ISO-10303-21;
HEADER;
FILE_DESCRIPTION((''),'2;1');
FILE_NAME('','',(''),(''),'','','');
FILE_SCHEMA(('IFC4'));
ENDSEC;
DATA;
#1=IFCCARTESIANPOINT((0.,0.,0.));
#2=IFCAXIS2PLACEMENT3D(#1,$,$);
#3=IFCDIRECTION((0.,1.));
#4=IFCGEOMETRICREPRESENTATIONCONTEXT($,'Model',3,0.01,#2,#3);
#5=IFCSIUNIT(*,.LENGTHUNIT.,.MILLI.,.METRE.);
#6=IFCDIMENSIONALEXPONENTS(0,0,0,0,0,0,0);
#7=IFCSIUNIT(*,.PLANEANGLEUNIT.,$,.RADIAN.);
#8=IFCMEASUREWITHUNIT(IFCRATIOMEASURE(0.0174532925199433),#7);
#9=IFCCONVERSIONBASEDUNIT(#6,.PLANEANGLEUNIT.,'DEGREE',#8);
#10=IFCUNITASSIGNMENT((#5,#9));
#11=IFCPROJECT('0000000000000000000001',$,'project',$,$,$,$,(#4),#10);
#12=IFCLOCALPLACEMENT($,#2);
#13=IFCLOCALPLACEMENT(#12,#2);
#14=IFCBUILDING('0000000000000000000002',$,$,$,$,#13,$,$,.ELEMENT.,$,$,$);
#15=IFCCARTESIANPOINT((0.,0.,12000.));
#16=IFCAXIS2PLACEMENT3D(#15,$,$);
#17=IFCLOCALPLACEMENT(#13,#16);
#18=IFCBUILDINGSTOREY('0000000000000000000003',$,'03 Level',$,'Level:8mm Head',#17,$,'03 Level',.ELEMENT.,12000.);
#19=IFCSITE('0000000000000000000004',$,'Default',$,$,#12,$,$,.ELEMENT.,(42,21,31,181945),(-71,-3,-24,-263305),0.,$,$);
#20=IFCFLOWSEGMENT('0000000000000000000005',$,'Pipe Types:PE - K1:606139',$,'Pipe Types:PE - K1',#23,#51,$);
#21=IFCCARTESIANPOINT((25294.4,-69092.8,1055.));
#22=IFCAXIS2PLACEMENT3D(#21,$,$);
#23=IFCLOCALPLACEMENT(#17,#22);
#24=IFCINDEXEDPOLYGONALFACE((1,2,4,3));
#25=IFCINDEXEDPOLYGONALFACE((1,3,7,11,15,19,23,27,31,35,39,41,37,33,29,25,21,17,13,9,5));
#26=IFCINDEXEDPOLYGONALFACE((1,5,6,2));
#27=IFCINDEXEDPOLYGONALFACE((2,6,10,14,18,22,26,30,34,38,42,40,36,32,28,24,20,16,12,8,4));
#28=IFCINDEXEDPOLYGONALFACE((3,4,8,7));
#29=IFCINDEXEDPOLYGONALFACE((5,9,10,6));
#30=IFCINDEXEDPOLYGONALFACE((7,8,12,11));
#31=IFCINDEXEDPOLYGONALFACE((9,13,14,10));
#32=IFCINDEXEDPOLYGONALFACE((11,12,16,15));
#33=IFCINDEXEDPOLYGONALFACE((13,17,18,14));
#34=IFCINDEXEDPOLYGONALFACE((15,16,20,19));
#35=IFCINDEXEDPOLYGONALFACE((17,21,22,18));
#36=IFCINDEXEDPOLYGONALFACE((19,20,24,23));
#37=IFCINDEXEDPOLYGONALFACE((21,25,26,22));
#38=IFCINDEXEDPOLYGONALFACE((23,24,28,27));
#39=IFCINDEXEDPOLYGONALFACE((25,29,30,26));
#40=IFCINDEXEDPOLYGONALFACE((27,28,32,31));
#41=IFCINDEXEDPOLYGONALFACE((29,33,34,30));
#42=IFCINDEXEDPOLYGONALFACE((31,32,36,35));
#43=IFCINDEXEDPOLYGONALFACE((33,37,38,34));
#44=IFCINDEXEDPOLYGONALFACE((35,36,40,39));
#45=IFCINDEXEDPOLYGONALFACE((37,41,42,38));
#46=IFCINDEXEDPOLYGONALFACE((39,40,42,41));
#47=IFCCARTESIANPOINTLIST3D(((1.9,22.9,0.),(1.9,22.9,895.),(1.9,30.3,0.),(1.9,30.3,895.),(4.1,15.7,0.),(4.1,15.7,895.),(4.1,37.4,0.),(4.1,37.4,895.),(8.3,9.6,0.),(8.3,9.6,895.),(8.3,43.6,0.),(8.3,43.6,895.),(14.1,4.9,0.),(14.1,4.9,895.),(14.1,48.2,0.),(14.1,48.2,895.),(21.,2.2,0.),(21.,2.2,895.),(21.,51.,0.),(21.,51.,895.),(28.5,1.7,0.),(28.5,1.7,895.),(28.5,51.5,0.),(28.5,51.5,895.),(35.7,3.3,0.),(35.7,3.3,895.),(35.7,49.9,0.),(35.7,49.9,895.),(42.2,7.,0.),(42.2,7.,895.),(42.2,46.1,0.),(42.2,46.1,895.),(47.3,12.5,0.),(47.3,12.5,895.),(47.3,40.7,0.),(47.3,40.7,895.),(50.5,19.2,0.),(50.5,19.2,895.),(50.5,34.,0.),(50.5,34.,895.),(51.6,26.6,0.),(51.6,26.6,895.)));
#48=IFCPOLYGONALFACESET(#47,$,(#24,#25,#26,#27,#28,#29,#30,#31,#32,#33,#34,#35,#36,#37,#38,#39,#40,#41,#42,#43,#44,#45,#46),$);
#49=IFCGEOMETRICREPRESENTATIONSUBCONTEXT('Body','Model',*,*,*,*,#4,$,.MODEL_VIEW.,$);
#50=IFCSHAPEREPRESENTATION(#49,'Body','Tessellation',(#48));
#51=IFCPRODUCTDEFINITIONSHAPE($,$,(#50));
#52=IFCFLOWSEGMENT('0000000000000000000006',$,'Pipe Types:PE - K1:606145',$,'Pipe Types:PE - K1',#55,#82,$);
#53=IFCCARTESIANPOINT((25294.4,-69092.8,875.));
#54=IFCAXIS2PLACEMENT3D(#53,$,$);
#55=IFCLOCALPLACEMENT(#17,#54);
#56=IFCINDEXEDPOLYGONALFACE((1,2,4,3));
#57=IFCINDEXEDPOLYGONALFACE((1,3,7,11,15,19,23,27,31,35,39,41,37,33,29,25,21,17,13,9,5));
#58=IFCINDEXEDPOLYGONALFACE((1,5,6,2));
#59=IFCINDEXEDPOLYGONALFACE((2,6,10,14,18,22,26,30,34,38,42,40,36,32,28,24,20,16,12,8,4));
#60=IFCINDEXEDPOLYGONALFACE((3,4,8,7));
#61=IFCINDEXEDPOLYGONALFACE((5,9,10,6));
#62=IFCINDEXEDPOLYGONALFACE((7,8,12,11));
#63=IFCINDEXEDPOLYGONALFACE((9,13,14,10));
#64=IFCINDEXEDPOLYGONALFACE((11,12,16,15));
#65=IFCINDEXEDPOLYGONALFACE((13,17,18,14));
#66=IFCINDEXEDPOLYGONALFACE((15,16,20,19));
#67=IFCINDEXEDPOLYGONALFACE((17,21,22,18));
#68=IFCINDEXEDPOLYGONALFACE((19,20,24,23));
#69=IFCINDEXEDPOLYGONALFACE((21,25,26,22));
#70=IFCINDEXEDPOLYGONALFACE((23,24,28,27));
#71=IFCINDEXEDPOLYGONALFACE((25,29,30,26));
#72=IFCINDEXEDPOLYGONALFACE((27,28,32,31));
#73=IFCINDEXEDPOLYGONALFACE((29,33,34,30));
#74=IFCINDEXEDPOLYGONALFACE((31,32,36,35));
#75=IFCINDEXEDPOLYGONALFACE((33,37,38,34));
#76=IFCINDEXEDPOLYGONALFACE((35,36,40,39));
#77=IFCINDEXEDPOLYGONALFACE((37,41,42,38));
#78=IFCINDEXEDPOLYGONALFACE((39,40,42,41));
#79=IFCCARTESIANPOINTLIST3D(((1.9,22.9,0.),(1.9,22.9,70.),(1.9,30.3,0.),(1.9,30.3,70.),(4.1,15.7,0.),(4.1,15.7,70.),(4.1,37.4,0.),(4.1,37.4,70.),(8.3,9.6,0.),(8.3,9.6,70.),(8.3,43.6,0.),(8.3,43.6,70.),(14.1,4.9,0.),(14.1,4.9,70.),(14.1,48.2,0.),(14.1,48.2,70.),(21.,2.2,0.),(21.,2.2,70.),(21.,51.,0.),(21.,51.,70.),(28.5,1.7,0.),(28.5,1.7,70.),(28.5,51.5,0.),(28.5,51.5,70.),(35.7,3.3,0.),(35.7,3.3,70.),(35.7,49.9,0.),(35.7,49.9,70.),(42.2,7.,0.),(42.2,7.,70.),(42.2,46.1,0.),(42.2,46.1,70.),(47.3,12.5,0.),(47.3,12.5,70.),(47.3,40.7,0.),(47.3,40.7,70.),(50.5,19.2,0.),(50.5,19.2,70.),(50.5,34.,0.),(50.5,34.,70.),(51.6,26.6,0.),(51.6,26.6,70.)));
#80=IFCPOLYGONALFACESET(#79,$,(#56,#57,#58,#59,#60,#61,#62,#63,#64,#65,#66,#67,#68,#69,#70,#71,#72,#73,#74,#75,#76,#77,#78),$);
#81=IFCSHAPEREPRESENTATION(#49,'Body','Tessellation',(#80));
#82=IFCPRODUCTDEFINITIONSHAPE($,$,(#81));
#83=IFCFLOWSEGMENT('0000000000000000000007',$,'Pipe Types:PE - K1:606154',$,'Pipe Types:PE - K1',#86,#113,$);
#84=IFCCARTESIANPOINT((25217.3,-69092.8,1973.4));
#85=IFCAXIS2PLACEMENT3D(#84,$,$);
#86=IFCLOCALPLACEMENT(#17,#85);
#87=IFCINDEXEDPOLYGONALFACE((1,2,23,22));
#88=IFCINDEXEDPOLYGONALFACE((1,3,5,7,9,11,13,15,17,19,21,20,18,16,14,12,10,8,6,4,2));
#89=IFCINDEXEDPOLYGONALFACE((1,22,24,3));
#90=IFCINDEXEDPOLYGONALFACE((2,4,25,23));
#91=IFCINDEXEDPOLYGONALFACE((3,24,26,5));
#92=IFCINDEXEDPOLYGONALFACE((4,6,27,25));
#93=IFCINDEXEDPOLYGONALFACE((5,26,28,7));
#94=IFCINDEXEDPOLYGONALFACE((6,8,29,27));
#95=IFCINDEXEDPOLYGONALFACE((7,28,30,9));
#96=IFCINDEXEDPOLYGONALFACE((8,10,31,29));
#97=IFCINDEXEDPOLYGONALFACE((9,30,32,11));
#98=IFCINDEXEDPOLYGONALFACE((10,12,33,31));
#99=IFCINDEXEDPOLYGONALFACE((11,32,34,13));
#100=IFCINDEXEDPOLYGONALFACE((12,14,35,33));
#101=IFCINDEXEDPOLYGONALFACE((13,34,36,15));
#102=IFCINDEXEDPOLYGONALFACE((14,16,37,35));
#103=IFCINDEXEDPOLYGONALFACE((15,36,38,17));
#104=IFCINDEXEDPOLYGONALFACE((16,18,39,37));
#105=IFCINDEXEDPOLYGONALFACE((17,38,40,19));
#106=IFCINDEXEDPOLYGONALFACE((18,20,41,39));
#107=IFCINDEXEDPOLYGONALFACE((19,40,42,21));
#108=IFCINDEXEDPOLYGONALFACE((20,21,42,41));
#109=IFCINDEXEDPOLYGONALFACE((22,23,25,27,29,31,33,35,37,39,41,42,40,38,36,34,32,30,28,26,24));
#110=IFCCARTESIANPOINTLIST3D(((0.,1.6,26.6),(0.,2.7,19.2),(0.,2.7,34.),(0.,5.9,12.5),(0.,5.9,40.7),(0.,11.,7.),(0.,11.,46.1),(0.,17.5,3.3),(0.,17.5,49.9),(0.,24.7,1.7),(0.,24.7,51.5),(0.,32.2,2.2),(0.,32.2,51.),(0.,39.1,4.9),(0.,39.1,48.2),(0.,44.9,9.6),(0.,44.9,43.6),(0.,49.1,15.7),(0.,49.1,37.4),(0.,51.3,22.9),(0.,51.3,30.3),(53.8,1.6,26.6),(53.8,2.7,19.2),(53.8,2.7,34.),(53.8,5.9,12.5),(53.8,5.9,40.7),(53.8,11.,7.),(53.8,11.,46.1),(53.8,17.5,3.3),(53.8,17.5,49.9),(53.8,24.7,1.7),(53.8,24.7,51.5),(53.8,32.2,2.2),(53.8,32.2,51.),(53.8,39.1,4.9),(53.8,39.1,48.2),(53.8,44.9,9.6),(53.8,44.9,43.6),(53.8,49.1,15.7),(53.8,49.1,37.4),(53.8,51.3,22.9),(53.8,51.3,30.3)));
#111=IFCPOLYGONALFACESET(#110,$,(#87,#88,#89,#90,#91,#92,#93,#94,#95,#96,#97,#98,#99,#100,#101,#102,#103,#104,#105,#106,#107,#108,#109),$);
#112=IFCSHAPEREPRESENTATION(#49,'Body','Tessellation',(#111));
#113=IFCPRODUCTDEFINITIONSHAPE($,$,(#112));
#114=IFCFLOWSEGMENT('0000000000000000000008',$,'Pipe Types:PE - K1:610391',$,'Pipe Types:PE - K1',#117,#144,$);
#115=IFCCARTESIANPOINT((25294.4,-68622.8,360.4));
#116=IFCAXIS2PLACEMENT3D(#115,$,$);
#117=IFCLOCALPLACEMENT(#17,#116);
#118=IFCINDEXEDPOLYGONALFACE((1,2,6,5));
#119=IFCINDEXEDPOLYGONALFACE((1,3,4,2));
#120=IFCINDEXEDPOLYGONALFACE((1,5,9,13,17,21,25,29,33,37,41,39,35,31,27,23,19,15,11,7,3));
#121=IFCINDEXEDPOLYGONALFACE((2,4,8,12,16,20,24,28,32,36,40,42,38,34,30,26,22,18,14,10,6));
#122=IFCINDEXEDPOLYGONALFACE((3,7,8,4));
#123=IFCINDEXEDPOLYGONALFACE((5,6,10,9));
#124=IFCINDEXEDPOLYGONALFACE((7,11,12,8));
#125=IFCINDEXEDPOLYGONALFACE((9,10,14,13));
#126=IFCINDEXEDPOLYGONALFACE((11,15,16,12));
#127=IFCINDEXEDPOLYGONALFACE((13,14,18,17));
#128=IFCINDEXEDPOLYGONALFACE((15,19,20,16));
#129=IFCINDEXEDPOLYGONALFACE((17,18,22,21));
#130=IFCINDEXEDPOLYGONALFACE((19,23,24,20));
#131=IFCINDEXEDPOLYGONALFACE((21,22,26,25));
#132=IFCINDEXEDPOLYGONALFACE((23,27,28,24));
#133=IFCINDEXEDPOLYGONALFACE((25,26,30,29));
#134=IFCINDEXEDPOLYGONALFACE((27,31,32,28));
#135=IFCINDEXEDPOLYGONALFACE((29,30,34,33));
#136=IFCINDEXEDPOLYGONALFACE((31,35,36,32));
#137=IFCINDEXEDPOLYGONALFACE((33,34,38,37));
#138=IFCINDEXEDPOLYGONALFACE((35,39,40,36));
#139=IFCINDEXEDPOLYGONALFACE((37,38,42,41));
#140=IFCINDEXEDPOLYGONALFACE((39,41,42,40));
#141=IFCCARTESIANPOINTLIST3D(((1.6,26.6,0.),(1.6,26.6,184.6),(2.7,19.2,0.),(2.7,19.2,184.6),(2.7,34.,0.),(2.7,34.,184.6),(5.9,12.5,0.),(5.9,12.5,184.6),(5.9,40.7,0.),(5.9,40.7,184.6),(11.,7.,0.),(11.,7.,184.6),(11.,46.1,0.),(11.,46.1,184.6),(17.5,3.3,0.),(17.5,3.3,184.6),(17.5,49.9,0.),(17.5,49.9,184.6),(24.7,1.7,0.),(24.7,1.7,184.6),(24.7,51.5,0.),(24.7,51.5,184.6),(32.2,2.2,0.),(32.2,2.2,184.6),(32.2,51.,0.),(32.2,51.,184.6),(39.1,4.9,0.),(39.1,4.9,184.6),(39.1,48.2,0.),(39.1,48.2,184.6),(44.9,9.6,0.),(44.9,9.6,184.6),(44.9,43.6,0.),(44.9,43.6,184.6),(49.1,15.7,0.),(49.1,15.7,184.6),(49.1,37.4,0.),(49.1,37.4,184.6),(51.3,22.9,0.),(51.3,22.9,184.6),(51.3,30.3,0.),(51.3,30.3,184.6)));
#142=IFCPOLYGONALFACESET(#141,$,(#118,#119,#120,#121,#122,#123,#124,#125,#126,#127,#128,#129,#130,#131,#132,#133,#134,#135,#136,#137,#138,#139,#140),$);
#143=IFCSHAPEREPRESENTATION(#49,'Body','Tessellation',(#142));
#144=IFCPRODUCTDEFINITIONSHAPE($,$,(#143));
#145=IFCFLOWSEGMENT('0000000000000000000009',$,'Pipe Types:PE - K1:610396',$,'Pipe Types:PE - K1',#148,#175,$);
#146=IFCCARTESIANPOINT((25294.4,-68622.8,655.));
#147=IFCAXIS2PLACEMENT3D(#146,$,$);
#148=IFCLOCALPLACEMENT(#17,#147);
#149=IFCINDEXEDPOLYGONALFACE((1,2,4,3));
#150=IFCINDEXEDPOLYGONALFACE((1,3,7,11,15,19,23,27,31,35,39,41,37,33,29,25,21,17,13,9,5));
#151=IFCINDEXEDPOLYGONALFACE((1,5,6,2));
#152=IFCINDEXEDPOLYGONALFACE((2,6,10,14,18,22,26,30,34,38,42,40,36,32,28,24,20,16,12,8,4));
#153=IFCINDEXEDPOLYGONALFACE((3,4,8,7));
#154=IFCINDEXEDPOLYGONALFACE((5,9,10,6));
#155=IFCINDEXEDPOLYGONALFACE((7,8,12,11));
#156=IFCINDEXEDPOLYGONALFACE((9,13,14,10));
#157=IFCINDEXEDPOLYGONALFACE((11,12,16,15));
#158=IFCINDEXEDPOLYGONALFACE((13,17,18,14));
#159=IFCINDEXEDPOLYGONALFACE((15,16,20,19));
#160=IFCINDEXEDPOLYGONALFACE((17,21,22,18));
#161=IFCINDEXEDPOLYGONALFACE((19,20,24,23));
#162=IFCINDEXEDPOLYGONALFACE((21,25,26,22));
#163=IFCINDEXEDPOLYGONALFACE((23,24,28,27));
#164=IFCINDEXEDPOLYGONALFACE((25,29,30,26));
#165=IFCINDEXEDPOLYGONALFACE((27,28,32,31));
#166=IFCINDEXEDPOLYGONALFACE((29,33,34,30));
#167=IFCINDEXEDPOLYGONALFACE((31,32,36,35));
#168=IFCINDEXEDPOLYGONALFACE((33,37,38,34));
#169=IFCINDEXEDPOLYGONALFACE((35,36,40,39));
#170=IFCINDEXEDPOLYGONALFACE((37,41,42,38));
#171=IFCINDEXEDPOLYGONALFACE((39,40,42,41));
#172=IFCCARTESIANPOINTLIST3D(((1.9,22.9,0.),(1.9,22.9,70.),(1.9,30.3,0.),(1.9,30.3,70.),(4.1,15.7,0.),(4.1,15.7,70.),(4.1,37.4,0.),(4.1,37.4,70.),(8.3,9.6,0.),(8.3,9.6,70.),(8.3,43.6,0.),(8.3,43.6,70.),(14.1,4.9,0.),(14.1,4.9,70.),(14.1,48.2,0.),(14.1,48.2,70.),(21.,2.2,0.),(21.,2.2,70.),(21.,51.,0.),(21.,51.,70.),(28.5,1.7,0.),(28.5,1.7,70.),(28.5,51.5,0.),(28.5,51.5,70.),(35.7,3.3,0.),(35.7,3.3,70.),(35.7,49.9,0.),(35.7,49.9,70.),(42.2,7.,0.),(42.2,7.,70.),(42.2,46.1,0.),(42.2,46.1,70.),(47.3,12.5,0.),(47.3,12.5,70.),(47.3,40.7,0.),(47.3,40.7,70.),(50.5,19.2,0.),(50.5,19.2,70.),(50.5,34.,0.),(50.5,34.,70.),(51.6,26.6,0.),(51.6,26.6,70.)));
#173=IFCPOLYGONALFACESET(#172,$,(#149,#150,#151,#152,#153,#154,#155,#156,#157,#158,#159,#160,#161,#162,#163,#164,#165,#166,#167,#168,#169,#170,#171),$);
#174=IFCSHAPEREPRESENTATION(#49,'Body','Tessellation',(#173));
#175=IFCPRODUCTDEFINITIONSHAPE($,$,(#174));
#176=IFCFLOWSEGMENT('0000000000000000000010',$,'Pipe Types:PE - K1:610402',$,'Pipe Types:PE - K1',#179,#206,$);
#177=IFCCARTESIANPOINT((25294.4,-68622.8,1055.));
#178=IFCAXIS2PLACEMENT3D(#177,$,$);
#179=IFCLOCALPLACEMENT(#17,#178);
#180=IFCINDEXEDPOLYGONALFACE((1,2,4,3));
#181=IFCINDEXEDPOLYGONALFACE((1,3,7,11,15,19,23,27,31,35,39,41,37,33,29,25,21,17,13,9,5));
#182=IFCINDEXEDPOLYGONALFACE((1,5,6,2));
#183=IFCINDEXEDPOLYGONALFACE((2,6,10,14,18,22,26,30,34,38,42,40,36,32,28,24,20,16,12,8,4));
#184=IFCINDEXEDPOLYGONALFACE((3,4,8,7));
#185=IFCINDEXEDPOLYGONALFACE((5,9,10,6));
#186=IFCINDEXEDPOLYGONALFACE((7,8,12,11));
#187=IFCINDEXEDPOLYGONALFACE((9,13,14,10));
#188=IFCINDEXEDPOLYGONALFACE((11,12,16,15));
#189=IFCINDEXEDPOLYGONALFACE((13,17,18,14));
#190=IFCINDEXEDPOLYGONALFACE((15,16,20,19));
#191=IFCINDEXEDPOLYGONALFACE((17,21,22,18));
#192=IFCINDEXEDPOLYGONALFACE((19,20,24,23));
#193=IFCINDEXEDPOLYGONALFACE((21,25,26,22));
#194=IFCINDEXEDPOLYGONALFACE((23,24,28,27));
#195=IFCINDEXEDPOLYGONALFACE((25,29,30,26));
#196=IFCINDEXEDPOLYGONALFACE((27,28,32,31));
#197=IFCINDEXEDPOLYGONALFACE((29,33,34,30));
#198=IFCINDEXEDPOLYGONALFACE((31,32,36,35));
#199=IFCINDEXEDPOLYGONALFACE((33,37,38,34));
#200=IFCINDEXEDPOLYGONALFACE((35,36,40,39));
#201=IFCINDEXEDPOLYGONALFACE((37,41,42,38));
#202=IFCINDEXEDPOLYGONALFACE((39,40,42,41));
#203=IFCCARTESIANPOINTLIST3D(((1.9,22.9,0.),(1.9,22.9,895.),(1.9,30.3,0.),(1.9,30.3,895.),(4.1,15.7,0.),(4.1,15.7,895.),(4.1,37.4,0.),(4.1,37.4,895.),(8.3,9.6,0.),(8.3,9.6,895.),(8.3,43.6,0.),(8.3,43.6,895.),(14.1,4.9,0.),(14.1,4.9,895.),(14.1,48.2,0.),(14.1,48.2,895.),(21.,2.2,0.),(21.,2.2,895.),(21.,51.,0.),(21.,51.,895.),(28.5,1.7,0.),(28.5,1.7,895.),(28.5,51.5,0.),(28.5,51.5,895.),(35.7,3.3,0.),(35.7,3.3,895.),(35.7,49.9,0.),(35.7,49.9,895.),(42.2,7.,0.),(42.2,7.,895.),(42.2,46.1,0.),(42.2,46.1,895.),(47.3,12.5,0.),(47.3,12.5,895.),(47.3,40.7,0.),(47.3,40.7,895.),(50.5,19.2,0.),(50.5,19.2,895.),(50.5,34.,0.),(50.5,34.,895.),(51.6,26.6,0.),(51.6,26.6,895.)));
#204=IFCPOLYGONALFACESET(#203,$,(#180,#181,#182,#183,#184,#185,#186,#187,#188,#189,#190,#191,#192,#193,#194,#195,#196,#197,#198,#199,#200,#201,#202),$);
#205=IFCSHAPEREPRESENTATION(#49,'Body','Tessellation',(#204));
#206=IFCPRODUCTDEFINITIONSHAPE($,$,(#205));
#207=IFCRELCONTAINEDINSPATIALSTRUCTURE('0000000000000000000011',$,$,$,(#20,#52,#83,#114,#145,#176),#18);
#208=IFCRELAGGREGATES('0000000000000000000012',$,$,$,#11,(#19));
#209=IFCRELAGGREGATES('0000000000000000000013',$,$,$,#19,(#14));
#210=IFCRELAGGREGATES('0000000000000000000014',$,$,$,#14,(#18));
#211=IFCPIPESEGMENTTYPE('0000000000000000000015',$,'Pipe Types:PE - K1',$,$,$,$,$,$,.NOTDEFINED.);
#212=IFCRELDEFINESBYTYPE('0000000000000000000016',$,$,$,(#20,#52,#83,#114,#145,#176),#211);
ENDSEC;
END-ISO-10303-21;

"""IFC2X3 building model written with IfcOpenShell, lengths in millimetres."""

from ifc_helpers import new_model, entity, si_unit, converted_unit, direction, frame, frame_2d, origin, origin_2d_with_axis, place, context, subcontext, project, spatial, circle, extrude, type_object, element, save


model = new_model("IFC2X3")

# Units and contexts
model_context = context("Model", 3, precision=0.01, world=origin(), true_north=direction((0.0, 1.0)))
body_context = subcontext(model_context, "Body", "Model", "MODEL_VIEW")
ifc_project = project(units=[si_unit("LENGTHUNIT", "METRE", prefix="MILLI"), converted_unit("PLANEANGLEUNIT", "DEGREE", entity("IfcRatioMeasure", 0.0174532925199433), si_unit("PLANEANGLEUNIT", "RADIAN"), dimensions=[0, 0, 0, 0, 0, 0, 0])], contexts=[model_context])

# Site, building, storey
site_placement = place(None, origin())
site = spatial("IfcSite", under=ifc_project, at=site_placement, Name="Default", CompositionType="ELEMENT", RefLatitude=(42, 21, 31, 181945), RefLongitude=(-71, -3, -24, -263305), RefElevation=0.0)
building_placement = place(site_placement, origin())
building = spatial("IfcBuilding", under=site, at=building_placement, CompositionType="ELEMENT")
storey_placement = place(building_placement, frame((0.0, 0.0, 12000.0)))
storey = spatial("IfcBuildingStorey", under=building, at=storey_placement, Name="03 Level", ObjectType="Level:8mm Head", LongName="03 Level", CompositionType="ELEMENT", Elevation=12000.0)

# Flow segments
pipe_segment_type_1 = type_object("IfcPipeSegmentType", Name="Pipe Types:PE - K1", PredefinedType="NOTDEFINED")
flow_segment_1_placement = place(storey_placement, frame((25294.4, -69092.8, 1055.0)))
element("IfcFlowSegment", 1, at=flow_segment_1_placement, inside=storey, type_object=pipe_segment_type_1, Name="Pipe Types:PE - K1:606139", ObjectType="Pipe Types:PE - K1", context=body_context, shape_type="SweptSolid", body=[
    extrude(circle(Radius=25.0, at=frame_2d((0.0, 0.0), x_axis=(1.0, 0.0))), frame((26.6, 26.6, 0.0)), (0.0, 0.0, 1.0), 895.0),
])
flow_segment_2_placement = place(storey_placement, frame((25294.4, -69092.8, 875.0)))
element("IfcFlowSegment", 2, at=flow_segment_2_placement, inside=storey, type_object=pipe_segment_type_1, Name="Pipe Types:PE - K1:606145", ObjectType="Pipe Types:PE - K1", context=body_context, shape_type="SweptSolid", body=[
    extrude(circle(Radius=25.0, at=origin_2d_with_axis()), frame((26.6, 26.6, 0.0)), (0.0, 0.0, 1.0), 70.0),
])
flow_segment_3_placement = place(storey_placement, frame((25217.3, -69092.8, 1973.4)))
element("IfcFlowSegment", 3, at=flow_segment_3_placement, inside=storey, type_object=pipe_segment_type_1, Name="Pipe Types:PE - K1:606154", ObjectType="Pipe Types:PE - K1", context=body_context, shape_type="SweptSolid", body=[
    extrude(circle(Radius=25.0, at=frame_2d((0.0, 0.0), x_axis=(1.0, 0.0))), frame((0.0, 26.6, 26.6), z_axis=(1.0, 0.0, 0.0), x_axis=(0.0, -1.0, 0.0)), (0.0, 0.0, 1.0), 53.8),
])
flow_segment_4_placement = place(storey_placement, frame((25294.4, -68622.8, 360.4)))
element("IfcFlowSegment", 4, at=flow_segment_4_placement, inside=storey, type_object=pipe_segment_type_1, Name="Pipe Types:PE - K1:610391", ObjectType="Pipe Types:PE - K1", context=body_context, shape_type="SweptSolid", body=[
    extrude(circle(Radius=25.0, at=frame_2d((0.0, 0.0), x_axis=(1.0, 0.0))), frame((26.6, 26.6, 0.0), z_axis=(0.0, 0.0, 1.0), x_axis=(-1.0, 0.0, 0.0)), (0.0, 0.0, 1.0), 184.6),
])
flow_segment_5_placement = place(storey_placement, frame((25294.4, -68622.8, 655.0)))
element("IfcFlowSegment", 5, at=flow_segment_5_placement, inside=storey, type_object=pipe_segment_type_1, Name="Pipe Types:PE - K1:610396", ObjectType="Pipe Types:PE - K1", context=body_context, shape_type="SweptSolid", body=[
    extrude(circle(Radius=25.0, at=frame_2d((0.0, 0.0), x_axis=(1.0, 0.0))), frame((26.6, 26.6, 0.0)), (0.0, 0.0, 1.0), 70.0),
])
flow_segment_6_placement = place(storey_placement, frame((25294.4, -68622.8, 1055.0)))
element("IfcFlowSegment", 6, at=flow_segment_6_placement, inside=storey, type_object=pipe_segment_type_1, Name="Pipe Types:PE - K1:610402", ObjectType="Pipe Types:PE - K1", context=body_context, shape_type="SweptSolid", body=[
    extrude(circle(Radius=25.0, at=origin_2d_with_axis()), frame((26.6, 26.6, 0.0)), (0.0, 0.0, 1.0), 895.0),
])

save(model, "model.ifc")
